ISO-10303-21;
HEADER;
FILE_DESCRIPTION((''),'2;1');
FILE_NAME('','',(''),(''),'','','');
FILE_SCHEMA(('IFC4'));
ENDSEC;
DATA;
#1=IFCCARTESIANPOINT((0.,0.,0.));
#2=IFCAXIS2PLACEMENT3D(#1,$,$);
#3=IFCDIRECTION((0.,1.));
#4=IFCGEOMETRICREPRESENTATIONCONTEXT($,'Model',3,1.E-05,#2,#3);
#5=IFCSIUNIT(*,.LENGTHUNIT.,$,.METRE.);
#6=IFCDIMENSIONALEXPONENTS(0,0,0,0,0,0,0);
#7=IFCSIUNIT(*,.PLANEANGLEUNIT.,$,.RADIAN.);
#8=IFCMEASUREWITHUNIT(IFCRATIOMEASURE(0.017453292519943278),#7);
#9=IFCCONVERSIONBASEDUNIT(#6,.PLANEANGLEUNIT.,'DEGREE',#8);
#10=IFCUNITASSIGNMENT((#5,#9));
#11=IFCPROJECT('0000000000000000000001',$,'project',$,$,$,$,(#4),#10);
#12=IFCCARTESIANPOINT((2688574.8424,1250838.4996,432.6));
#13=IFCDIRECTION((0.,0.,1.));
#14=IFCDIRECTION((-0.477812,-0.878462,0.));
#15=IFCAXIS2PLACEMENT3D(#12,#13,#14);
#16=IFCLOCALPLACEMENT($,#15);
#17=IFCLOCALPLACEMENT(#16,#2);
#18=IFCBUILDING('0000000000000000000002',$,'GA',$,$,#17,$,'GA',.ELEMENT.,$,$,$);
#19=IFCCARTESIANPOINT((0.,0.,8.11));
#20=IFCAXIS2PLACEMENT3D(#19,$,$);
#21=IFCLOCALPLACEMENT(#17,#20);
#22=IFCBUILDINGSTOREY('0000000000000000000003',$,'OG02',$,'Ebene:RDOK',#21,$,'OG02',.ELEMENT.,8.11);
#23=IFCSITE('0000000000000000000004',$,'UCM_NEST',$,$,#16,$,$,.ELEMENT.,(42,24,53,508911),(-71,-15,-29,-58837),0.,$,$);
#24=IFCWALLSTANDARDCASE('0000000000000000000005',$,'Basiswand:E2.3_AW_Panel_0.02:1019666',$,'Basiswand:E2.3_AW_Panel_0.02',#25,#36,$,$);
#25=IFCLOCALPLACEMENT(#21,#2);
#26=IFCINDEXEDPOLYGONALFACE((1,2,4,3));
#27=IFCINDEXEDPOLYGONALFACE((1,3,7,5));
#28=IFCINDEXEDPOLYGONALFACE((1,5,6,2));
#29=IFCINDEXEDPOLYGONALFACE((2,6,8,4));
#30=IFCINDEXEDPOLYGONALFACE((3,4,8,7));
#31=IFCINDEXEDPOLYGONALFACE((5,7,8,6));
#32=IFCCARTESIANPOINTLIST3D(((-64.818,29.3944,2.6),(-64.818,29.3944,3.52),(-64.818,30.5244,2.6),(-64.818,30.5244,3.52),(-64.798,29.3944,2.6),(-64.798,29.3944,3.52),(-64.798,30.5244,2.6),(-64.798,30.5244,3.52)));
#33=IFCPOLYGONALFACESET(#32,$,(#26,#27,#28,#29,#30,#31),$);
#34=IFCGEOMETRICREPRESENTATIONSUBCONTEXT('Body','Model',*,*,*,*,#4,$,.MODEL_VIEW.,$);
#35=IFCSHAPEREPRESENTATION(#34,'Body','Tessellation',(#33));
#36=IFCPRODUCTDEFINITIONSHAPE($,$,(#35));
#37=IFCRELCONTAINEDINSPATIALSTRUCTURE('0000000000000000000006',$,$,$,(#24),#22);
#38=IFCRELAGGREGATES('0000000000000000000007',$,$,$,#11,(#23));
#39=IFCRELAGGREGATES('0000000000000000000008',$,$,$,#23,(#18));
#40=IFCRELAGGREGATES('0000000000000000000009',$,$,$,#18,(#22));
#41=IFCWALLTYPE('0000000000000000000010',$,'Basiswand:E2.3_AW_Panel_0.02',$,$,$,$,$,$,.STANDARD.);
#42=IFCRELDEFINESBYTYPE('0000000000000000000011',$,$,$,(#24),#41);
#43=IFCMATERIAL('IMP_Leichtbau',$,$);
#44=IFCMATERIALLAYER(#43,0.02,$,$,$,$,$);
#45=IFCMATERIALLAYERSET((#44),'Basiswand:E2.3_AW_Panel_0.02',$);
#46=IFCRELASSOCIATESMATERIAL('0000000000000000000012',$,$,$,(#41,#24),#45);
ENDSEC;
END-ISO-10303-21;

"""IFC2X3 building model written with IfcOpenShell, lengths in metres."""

from ifc_helpers import new_model, entity, si_unit, converted_unit, direction, frame, frame_2d, origin, place, context, subcontext, project, spatial, polyline, rectangle, extrude, clip, bounded_halfspace, material, layer, layer_set, layer_usage, type_object, element, save


model = new_model("IFC2X3")

# Units and contexts
model_context = context("Model", 3, precision=1e-05, world=origin(), true_north=direction((0.0, 1.0)))
body_context = subcontext(model_context, "Body", "Model", "MODEL_VIEW")
ifc_project = project(units=[si_unit("LENGTHUNIT", "METRE"), converted_unit("PLANEANGLEUNIT", "DEGREE", entity("IfcRatioMeasure", 0.017453292519943278), si_unit("PLANEANGLEUNIT", "RADIAN"), dimensions=[0, 0, 0, 0, 0, 0, 0])], contexts=[model_context])

# Site, building, storey
site_placement = place(None, frame((2688574.8424, 1250838.4996, 432.6), z_axis=(0.0, 0.0, 1.0), x_axis=(-0.477812, -0.878462, 0.0)))
site = spatial("IfcSite", under=ifc_project, at=site_placement, Name="UCM_NEST", CompositionType="ELEMENT", RefLatitude=(42, 24, 53, 508911), RefLongitude=(-71, -15, -29, -58837), RefElevation=0.0)
building_placement = place(site_placement, origin())
building = spatial("IfcBuilding", under=site, at=building_placement, Name="GA", LongName="GA", CompositionType="ELEMENT")
storey_placement = place(building_placement, frame((0.0, 0.0, 8.11)))
storey = spatial("IfcBuildingStorey", under=building, at=storey_placement, Name="OG02", ObjectType="Ebene:RDOK", LongName="OG02", CompositionType="ELEMENT", Elevation=8.11)

# Wall
ifc_material_1 = material(Name="IMP_Leichtbau")
ifc_layer_1 = layer(ifc_material_1, 0.02)
ifc_layer_set_1 = layer_set([ifc_layer_1], Name="Basiswand:E2.3_AW_Panel_0.02")
ifc_layer_usage_1 = layer_usage(ifc_layer_set_1, "AXIS2", "NEGATIVE", 0.01)
wall_type_1 = type_object("IfcWallType", Name="Basiswand:E2.3_AW_Panel_0.02", PredefinedType="STANDARD", material=ifc_layer_set_1)
wall_1_placement = place(storey_placement, frame((-64.808, 30.5244, 2.6), z_axis=(0.0, 0.0, 1.0), x_axis=(0.0, -1.0, 0.0)))
element("IfcWallStandardCase", 1, at=wall_1_placement, inside=storey, type_object=wall_type_1, material=ifc_layer_usage_1, Name="Basiswand:E2.3_AW_Panel_0.02:1019666", ObjectType="Basiswand:E2.3_AW_Panel_0.02", context=body_context, shape_type="Clipping", body=[
    clip(extrude(rectangle(XDim=1.13, YDim=0.02, at=frame_2d((0.565, 0.0), x_axis=(-1.0, 0.0))), origin(), (0.0, 0.0, 1.0), 0.92), bounded_halfspace(frame((0.0, -0.01, 0.92), z_axis=(0.0, 0.0, -1.0), x_axis=(0.0, -1.0, 0.0)), True, frame((0.0, -0.01, 0.92), z_axis=(0.0, 0.0, -1.0), x_axis=(0.0, -1.0, 0.0)), polyline([(0.0, 0.0), (-0.02, 0.0), (-0.02, -1.13), (0.0, -1.13), (0.0, 0.0)]))),
])

save(model, "model.ifc")
